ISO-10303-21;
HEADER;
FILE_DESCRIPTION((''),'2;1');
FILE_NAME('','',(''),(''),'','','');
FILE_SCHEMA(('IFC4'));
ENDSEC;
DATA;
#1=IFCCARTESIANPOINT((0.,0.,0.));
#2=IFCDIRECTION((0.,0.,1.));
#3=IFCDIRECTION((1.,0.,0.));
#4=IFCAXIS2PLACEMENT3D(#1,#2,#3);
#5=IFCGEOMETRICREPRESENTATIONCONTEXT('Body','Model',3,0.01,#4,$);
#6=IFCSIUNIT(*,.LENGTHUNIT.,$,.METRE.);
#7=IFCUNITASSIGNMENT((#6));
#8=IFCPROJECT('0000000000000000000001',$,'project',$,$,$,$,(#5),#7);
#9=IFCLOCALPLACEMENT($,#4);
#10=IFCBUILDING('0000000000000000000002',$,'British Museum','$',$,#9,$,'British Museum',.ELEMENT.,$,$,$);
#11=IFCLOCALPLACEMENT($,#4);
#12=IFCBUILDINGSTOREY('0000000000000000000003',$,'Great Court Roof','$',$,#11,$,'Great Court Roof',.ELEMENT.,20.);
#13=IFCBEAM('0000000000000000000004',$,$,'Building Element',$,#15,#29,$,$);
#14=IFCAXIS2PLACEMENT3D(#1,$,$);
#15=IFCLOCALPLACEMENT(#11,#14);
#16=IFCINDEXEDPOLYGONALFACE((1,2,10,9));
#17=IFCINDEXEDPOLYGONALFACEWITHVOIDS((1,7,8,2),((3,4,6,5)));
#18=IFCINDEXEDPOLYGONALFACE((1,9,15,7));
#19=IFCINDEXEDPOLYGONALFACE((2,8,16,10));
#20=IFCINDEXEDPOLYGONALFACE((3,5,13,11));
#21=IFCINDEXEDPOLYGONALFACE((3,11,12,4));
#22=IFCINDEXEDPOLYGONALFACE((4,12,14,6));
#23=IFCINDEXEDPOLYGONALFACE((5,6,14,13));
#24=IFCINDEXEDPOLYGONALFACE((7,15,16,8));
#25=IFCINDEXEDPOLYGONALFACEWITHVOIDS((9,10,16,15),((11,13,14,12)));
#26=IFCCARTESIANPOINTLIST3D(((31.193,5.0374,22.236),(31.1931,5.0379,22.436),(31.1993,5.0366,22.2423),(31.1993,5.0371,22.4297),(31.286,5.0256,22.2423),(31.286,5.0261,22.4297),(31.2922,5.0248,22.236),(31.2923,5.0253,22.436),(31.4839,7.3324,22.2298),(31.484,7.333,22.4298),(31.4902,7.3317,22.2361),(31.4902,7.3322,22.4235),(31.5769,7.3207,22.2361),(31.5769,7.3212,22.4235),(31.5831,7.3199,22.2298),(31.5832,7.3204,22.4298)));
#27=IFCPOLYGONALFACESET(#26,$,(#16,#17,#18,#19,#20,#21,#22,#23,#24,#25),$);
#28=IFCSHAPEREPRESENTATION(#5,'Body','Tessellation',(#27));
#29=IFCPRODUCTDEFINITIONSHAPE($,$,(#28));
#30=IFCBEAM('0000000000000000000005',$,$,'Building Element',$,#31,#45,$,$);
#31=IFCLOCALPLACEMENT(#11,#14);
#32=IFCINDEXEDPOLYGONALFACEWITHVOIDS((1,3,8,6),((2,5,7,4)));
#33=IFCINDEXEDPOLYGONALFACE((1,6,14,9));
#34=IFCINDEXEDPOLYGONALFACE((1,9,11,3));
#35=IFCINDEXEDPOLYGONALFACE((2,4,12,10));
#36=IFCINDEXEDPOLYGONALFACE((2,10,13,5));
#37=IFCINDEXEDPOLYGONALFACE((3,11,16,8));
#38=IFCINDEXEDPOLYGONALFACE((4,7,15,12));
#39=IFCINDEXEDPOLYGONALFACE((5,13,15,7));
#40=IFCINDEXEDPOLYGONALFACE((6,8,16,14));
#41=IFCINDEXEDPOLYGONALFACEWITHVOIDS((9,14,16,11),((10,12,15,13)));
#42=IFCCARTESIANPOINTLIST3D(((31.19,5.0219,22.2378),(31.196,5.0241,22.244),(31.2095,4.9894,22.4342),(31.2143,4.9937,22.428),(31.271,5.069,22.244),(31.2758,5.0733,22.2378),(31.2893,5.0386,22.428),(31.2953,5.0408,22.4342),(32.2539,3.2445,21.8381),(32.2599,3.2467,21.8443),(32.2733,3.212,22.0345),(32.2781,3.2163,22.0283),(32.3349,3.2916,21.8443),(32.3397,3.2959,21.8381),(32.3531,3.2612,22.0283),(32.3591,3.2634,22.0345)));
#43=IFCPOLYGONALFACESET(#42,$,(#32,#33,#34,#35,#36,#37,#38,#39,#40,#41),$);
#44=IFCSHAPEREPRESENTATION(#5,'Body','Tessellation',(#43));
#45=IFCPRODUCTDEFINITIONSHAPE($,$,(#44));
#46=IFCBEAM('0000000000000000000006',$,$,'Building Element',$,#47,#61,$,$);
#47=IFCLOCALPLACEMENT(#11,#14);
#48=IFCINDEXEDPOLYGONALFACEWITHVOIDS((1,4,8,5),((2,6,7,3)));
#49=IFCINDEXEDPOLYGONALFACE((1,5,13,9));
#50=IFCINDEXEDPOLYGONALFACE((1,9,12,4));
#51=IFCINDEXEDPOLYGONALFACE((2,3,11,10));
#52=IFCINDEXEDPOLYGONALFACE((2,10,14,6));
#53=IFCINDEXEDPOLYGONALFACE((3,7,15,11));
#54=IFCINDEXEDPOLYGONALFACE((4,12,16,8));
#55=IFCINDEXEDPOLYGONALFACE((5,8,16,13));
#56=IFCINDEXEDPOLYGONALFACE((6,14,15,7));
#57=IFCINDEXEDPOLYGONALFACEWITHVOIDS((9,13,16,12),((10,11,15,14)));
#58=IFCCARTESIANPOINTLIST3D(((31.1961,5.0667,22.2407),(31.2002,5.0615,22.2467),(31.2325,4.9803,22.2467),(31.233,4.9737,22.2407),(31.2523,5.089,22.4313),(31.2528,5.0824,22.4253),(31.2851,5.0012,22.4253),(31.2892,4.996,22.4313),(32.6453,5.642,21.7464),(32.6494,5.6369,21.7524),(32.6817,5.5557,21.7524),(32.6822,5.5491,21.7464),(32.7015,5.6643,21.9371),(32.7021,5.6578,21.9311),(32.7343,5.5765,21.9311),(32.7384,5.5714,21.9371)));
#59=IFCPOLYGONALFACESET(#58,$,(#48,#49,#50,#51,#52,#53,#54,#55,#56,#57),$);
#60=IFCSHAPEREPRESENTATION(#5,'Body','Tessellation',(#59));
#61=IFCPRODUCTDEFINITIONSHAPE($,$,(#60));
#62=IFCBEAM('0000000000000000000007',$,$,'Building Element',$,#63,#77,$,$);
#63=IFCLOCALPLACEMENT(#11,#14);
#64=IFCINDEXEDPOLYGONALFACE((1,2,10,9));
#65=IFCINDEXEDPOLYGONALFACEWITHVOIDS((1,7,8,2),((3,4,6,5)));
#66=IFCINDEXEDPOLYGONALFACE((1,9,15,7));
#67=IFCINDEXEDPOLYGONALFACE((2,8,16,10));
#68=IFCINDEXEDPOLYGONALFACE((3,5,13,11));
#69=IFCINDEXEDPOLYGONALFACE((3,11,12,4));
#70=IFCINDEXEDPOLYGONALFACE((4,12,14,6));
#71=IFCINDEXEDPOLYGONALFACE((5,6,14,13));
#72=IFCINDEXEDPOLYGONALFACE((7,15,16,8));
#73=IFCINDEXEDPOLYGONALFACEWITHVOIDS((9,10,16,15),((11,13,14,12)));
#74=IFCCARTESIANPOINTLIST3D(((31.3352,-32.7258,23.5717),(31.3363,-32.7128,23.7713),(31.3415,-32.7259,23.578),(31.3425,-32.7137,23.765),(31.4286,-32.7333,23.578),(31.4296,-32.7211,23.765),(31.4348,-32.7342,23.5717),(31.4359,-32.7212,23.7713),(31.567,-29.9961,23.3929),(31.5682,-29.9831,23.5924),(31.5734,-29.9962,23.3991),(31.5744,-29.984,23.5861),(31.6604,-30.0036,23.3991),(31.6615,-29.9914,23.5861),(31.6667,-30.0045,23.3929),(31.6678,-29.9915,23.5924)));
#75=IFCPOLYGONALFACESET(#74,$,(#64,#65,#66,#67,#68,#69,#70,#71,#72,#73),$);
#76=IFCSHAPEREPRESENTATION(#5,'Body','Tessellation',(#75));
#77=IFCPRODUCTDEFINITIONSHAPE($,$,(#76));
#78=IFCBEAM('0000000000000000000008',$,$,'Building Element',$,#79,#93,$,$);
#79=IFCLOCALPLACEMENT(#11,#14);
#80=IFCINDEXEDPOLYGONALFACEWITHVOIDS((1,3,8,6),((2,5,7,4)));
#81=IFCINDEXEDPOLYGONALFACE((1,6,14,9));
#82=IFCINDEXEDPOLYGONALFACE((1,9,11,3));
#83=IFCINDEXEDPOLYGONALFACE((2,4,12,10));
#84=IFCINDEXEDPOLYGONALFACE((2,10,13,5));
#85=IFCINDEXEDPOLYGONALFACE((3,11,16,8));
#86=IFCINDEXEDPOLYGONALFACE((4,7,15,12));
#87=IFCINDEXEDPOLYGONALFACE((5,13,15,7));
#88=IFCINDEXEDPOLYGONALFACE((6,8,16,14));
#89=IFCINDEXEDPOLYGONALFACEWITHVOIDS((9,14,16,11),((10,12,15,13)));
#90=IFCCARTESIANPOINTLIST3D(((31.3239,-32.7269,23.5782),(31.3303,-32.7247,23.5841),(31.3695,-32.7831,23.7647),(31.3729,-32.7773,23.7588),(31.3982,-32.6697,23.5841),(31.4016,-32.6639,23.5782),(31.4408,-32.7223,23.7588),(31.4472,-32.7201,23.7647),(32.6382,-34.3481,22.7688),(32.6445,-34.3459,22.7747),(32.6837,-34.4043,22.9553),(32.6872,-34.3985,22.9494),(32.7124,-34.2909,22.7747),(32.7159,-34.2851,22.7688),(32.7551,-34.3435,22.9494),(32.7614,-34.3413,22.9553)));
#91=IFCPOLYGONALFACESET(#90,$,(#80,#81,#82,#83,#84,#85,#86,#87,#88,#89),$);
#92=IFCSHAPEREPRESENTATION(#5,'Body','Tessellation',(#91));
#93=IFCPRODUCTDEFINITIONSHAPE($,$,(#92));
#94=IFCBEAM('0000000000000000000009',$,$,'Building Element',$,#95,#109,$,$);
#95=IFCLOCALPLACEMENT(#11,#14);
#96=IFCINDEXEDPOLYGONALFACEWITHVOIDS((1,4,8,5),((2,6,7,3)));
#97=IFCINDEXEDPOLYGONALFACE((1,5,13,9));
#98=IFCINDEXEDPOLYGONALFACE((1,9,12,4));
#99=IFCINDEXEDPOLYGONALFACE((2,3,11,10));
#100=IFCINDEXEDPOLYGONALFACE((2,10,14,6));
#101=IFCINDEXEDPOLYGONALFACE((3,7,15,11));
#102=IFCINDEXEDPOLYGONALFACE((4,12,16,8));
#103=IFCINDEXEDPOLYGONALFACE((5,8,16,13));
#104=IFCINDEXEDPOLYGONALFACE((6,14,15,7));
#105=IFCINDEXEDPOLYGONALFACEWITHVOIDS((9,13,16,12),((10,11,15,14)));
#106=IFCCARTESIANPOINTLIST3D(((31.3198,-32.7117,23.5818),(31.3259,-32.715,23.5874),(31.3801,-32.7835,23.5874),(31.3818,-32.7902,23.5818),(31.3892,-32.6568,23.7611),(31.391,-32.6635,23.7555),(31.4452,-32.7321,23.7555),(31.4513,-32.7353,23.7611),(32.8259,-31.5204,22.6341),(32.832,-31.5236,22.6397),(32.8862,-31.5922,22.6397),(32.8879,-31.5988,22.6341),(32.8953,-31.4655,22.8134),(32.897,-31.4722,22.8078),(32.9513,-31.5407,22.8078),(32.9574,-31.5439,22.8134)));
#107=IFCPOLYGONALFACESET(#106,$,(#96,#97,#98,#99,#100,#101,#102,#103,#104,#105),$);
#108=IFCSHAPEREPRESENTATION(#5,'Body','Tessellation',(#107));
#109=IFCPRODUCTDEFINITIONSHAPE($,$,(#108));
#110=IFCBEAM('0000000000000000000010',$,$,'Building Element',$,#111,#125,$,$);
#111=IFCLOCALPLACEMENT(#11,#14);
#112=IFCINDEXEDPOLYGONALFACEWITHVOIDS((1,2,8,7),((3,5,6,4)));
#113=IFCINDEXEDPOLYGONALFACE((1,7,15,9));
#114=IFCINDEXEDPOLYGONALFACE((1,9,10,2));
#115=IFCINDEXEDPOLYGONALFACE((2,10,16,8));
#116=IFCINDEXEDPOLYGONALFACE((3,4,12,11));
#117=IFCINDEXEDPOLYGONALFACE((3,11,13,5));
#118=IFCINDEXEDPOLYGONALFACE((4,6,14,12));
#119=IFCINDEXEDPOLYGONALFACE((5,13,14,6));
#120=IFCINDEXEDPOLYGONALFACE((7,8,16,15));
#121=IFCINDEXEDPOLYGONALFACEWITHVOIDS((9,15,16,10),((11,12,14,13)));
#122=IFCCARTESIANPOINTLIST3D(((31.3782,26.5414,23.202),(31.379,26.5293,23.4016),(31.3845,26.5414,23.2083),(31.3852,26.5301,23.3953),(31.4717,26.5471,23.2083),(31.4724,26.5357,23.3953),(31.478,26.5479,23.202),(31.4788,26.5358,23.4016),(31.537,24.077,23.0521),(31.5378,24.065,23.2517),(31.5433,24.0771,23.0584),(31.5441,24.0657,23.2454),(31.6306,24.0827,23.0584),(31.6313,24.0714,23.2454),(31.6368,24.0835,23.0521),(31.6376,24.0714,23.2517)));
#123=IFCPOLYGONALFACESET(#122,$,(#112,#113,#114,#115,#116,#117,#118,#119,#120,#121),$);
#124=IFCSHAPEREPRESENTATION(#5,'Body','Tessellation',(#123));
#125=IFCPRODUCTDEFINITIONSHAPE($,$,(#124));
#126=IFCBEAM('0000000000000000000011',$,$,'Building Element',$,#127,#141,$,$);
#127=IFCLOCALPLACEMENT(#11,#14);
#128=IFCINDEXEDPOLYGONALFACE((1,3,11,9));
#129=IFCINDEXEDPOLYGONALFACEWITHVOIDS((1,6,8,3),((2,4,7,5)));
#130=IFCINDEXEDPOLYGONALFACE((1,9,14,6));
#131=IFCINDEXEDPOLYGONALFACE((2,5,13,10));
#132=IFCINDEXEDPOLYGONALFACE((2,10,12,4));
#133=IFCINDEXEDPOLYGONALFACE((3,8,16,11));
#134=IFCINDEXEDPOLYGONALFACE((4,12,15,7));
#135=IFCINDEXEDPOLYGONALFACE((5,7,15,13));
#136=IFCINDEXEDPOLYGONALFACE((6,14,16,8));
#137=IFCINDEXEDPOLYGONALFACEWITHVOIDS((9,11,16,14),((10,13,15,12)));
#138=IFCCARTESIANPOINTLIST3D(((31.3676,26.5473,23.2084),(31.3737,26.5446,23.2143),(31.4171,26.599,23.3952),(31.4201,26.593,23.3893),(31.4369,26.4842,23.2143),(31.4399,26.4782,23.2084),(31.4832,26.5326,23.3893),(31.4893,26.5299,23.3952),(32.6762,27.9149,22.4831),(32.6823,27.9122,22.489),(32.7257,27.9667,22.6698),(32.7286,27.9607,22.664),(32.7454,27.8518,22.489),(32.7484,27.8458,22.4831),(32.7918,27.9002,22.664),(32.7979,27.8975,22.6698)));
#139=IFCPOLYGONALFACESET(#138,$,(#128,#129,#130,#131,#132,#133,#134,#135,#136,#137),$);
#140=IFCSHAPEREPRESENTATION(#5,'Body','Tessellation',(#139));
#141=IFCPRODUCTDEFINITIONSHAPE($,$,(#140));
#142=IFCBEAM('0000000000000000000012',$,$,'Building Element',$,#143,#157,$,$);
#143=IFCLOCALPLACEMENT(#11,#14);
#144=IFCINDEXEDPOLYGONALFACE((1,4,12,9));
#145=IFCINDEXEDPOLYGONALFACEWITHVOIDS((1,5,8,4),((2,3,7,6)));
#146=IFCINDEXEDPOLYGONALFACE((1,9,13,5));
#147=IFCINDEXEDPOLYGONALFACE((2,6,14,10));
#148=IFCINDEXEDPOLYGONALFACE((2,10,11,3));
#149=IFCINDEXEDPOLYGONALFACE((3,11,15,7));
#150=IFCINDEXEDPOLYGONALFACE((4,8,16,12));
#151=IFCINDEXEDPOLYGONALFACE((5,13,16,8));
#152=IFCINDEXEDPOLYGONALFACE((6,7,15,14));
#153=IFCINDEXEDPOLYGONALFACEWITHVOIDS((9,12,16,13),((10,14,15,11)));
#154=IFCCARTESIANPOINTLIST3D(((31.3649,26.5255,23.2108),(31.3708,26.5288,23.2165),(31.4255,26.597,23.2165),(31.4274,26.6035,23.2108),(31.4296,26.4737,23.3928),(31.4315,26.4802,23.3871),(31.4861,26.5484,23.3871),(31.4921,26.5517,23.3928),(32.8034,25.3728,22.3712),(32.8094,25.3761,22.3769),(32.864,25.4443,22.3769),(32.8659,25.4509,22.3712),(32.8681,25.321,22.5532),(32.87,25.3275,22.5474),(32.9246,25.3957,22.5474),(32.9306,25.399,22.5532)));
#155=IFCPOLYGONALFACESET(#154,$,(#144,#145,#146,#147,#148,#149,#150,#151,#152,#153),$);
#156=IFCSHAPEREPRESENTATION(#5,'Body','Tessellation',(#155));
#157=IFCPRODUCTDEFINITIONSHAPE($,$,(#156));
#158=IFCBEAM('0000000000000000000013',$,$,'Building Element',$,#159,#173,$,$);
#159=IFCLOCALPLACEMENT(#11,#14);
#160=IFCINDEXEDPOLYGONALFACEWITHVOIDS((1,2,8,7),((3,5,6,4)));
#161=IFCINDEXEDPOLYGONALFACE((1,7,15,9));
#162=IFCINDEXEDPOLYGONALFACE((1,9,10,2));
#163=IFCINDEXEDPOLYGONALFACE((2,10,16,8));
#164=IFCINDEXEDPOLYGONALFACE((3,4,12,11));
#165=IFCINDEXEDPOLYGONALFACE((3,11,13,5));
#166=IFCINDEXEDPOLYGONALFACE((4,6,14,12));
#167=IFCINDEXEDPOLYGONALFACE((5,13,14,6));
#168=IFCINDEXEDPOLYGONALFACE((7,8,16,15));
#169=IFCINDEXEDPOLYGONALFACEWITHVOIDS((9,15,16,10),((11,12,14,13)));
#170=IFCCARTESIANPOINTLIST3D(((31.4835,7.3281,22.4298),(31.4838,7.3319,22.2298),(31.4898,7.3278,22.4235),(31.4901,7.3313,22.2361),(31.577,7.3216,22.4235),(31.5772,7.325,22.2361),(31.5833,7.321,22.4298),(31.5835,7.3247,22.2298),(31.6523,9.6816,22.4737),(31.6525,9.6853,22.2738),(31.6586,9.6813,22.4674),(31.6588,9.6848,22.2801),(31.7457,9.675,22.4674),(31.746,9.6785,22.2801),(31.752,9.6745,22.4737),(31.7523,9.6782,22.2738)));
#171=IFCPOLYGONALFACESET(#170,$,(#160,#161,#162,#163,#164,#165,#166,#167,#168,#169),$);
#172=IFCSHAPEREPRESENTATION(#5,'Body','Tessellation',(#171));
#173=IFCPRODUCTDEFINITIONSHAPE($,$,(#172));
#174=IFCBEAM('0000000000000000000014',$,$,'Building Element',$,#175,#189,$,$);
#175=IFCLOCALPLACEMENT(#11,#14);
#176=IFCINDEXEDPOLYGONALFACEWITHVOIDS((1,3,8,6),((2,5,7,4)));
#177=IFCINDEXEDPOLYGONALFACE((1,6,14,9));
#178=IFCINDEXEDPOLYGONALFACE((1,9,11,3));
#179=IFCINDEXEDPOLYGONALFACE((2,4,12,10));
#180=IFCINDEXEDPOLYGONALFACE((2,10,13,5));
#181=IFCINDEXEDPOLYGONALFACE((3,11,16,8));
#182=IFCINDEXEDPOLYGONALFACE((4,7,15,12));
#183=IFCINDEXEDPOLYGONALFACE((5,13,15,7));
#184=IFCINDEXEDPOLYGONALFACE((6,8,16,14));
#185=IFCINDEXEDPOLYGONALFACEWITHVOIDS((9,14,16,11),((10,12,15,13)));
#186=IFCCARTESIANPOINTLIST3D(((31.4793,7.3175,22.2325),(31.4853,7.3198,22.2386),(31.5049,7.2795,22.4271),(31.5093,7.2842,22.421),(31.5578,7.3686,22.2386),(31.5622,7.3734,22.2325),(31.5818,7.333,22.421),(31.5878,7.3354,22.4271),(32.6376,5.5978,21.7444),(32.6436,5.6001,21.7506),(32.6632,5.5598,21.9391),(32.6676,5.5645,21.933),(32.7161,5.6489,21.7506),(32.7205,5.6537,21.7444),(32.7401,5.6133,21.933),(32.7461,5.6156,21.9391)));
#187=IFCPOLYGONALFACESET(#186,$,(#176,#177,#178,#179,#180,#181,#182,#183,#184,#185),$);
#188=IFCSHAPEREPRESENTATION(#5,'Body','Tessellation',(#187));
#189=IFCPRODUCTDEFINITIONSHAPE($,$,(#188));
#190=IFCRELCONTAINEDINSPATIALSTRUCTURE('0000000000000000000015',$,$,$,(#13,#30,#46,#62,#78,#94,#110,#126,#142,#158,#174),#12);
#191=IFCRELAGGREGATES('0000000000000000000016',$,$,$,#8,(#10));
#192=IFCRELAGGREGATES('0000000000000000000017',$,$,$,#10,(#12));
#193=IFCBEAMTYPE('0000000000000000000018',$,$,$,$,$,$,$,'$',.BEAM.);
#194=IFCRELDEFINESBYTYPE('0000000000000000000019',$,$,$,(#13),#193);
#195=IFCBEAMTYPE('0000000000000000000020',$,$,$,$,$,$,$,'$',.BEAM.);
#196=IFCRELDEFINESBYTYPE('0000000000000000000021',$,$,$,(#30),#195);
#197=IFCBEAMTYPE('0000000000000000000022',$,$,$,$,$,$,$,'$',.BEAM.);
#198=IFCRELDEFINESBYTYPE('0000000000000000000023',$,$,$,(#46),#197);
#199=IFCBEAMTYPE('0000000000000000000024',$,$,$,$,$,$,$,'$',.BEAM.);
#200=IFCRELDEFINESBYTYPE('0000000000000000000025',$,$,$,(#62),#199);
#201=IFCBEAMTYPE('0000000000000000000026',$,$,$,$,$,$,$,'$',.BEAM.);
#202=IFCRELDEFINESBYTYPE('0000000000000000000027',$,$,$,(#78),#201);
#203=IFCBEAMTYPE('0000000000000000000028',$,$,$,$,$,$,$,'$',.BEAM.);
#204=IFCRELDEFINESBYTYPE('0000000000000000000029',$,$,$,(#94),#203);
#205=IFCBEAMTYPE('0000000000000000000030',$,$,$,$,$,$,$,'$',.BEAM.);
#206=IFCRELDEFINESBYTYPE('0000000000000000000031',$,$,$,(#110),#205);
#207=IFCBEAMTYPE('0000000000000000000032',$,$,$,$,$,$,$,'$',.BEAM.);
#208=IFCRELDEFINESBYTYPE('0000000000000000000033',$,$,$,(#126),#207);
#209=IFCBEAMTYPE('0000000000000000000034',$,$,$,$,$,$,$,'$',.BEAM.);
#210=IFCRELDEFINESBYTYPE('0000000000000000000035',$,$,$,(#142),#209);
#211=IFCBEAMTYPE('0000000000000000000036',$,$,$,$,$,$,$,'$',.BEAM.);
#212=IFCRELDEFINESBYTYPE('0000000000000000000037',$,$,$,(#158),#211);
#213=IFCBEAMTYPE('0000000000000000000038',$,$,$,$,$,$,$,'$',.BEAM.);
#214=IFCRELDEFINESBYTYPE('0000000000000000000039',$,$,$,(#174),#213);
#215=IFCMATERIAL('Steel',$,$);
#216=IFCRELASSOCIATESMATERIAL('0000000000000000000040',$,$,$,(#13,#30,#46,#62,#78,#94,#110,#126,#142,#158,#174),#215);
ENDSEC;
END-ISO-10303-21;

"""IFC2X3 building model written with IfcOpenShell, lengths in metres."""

from ifc_helpers import new_model, si_unit, frame, origin_with_axes, origin_2d, place, context, project, spatial, hollow_rectangle, extrude, material, type_object, element, save


model = new_model("IFC2X3")

# Units and contexts
model_context = context("Model", 3, precision=0.01, world=origin_with_axes(), identifier="Body")
ifc_project = project(units=[si_unit("LENGTHUNIT", "METRE")], contexts=[model_context])

# Building, storey
building_placement = place(None, origin_with_axes())
building = spatial("IfcBuilding", under=ifc_project, at=building_placement, Name="British Museum", Description="$", LongName="British Museum", CompositionType="ELEMENT")
storey_placement = place(None, origin_with_axes())
storey = spatial("IfcBuildingStorey", under=building, at=storey_placement, Name="Great Court Roof", Description="$", LongName="Great Court Roof", CompositionType="ELEMENT", Elevation=20.0)

# Beams
ifc_material = material(Name="Steel")
beam_type_1 = type_object("IfcBeamType", ElementType="$", PredefinedType="BEAM")
beam_1_placement = place(None, origin_with_axes())
element("IfcBeam", 1, at=beam_1_placement, inside=storey, type_object=beam_type_1, material=ifc_material, Description="Building Element", context=model_context, shape_type="SweptSolid", body=[
    extrude(hollow_rectangle(XDim=0.1, YDim=0.2, WallThickness=0.0063, InnerFilletRadius=0.0, OuterFilletRadius=0.0, at=origin_2d()), frame((31.2427, 5.0313, 22.336), z_axis=(0.125736, 0.99206, -0.002679), x_axis=(-0.992064, 0.125737, 0.0)), (0.0, 0.0, 1.0), 2.3134),
])
beam_type_2 = type_object("IfcBeamType", ElementType="$", PredefinedType="BEAM")
beam_2_placement = place(None, origin_with_axes())
element("IfcBeam", 2, at=beam_2_placement, inside=storey, type_object=beam_type_2, material=ifc_material, Description="Building Element", context=model_context, shape_type="SweptSolid", body=[
    extrude(hollow_rectangle(XDim=0.1, YDim=0.2, WallThickness=0.0063, InnerFilletRadius=0.0, OuterFilletRadius=0.0, at=origin_2d()), frame((31.2427, 5.0313, 22.336), z_axis=(0.50427, -0.842507, -0.189454), x_axis=(0.858047, 0.513571, 0.0)), (0.0, 0.0, 1.0), 2.1097),
])
beam_type_3 = type_object("IfcBeamType", ElementType="$", PredefinedType="BEAM")
beam_3_placement = place(None, origin_with_axes())
element("IfcBeam", 3, at=beam_3_placement, inside=storey, type_object=beam_type_3, material=ifc_material, Description="Building Element", context=model_context, shape_type="SweptSolid", body=[
    extrude(hollow_rectangle(XDim=0.1, YDim=0.2, WallThickness=0.0063, InnerFilletRadius=0.0, OuterFilletRadius=0.0, at=origin_2d()), frame((31.2427, 5.0313, 22.336), z_axis=(0.885986, 0.351753, -0.302156), x_axis=(-0.369001, 0.929429, 0.0)), (0.0, 0.0, 1.0), 1.6357),
])
beam_type_4 = type_object("IfcBeamType", ElementType="$", PredefinedType="BEAM")
beam_4_placement = place(None, origin_with_axes())
element("IfcBeam", 4, at=beam_4_placement, inside=storey, type_object=beam_type_4, material=ifc_material, Description="Building Element", context=model_context, shape_type="SweptSolid", body=[
    extrude(hollow_rectangle(XDim=0.1, YDim=0.2, WallThickness=0.0063, InnerFilletRadius=0.0, OuterFilletRadius=0.0, at=origin_2d()), frame((31.3855, -32.7235, 23.6715), z_axis=(0.084462, 0.994295, -0.065136), x_axis=(-0.996411, 0.084642, 0.0)), (0.0, 0.0, 1.0), 2.7454),
])
beam_type_5 = type_object("IfcBeamType", ElementType="$", PredefinedType="BEAM")
beam_5_placement = place(None, origin_with_axes())
element("IfcBeam", 5, at=beam_5_placement, inside=storey, type_object=beam_type_5, material=ifc_material, Description="Building Element", context=model_context, shape_type="SweptSolid", body=[
    extrude(hollow_rectangle(XDim=0.1, YDim=0.2, WallThickness=0.0063, InnerFilletRadius=0.0, OuterFilletRadius=0.0, at=origin_2d()), frame((31.3855, -32.7235, 23.6715), z_axis=(0.587133, -0.724244, -0.361587), x_axis=(0.776804, 0.629742, 0.0)), (0.0, 0.0, 1.0), 2.2385),
])
beam_type_6 = type_object("IfcBeamType", ElementType="$", PredefinedType="BEAM")
beam_6_placement = place(None, origin_with_axes())
element("IfcBeam", 6, at=beam_6_placement, inside=storey, type_object=beam_type_6, material=ifc_material, Description="Building Element", context=model_context, shape_type="SweptSolid", body=[
    extrude(hollow_rectangle(XDim=0.1, YDim=0.2, WallThickness=0.0063, InnerFilletRadius=0.0, OuterFilletRadius=0.0, at=origin_2d()), frame((31.3855, -32.7235, 23.6715), z_axis=(0.703311, 0.556321, -0.442561), x_axis=(-0.620383, 0.784299, 0.0)), (0.0, 0.0, 1.0), 2.1414),
])
beam_type_7 = type_object("IfcBeamType", ElementType="$", PredefinedType="BEAM")
beam_7_placement = place(None, origin_with_axes())
element("IfcBeam", 7, at=beam_7_placement, inside=storey, type_object=beam_type_7, material=ifc_material, Description="Building Element", context=model_context, shape_type="SweptSolid", body=[
    extrude(hollow_rectangle(XDim=0.1, YDim=0.2, WallThickness=0.0063, InnerFilletRadius=0.0, OuterFilletRadius=0.0, at=origin_2d()), frame((31.4285, 26.5386, 23.3018), z_axis=(0.064204, -0.996096, -0.060588), x_axis=(0.997929, 0.064322, 0.0)), (0.0, 0.0, 1.0), 2.474),
])
beam_type_8 = type_object("IfcBeamType", ElementType="$", PredefinedType="BEAM")
beam_8_placement = place(None, origin_with_axes())
element("IfcBeam", 8, at=beam_8_placement, inside=storey, type_object=beam_type_8, material=ifc_material, Description="Building Element", context=model_context, shape_type="SweptSolid", body=[
    extrude(hollow_rectangle(XDim=0.1, YDim=0.2, WallThickness=0.0063, InnerFilletRadius=0.0, OuterFilletRadius=0.0, at=origin_2d()), frame((31.4285, 26.5386, 23.3018), z_axis=(0.645556, 0.6747, -0.357824), x_axis=(-0.72254, 0.691329, 0.0)), (0.0, 0.0, 1.0), 2.027),
])
beam_type_9 = type_object("IfcBeamType", ElementType="$", PredefinedType="BEAM")
beam_9_placement = place(None, origin_with_axes())
element("IfcBeam", 9, at=beam_9_placement, inside=storey, type_object=beam_type_9, material=ifc_material, Description="Building Element", context=model_context, shape_type="SweptSolid", body=[
    extrude(hollow_rectangle(XDim=0.1, YDim=0.2, WallThickness=0.0063, InnerFilletRadius=0.0, OuterFilletRadius=0.0, at=origin_2d()), frame((31.4285, 26.5386, 23.3018), z_axis=(0.710175, -0.56906, -0.414514), x_axis=(0.625311, 0.780375, 0.0)), (0.0, 0.0, 1.0), 2.0256),
])
beam_type_10 = type_object("IfcBeamType", ElementType="$", PredefinedType="BEAM")
beam_10_placement = place(None, origin_with_axes())
element("IfcBeam", 10, at=beam_10_placement, inside=storey, type_object=beam_type_10, material=ifc_material, Description="Building Element", context=model_context, shape_type="SweptSolid", body=[
    extrude(hollow_rectangle(XDim=0.1, YDim=0.2, WallThickness=0.0063, InnerFilletRadius=0.0, OuterFilletRadius=0.0, at=origin_2d()), frame((31.5335, 7.3264, 22.3298), z_axis=(0.071503, 0.997267, 0.018616), x_axis=(-0.99744, 0.071515, 0.0)), (0.0, 0.0, 1.0), 2.3599),
])
beam_type_11 = type_object("IfcBeamType", ElementType="$", PredefinedType="BEAM")
beam_11_placement = place(None, origin_with_axes())
element("IfcBeam", 11, at=beam_11_placement, inside=storey, type_object=beam_type_11, material=ifc_material, Description="Building Element", context=model_context, shape_type="SweptSolid", body=[
    extrude(hollow_rectangle(XDim=0.1, YDim=0.2, WallThickness=0.0063, InnerFilletRadius=0.0, OuterFilletRadius=0.0, at=origin_2d()), frame((31.5335, 7.3264, 22.3298), z_axis=(0.543792, -0.807339, -0.229117), x_axis=(0.829402, 0.558653, 0.0)), (0.0, 0.0, 1.0), 2.1301),
])

save(model, "model.ifc")
